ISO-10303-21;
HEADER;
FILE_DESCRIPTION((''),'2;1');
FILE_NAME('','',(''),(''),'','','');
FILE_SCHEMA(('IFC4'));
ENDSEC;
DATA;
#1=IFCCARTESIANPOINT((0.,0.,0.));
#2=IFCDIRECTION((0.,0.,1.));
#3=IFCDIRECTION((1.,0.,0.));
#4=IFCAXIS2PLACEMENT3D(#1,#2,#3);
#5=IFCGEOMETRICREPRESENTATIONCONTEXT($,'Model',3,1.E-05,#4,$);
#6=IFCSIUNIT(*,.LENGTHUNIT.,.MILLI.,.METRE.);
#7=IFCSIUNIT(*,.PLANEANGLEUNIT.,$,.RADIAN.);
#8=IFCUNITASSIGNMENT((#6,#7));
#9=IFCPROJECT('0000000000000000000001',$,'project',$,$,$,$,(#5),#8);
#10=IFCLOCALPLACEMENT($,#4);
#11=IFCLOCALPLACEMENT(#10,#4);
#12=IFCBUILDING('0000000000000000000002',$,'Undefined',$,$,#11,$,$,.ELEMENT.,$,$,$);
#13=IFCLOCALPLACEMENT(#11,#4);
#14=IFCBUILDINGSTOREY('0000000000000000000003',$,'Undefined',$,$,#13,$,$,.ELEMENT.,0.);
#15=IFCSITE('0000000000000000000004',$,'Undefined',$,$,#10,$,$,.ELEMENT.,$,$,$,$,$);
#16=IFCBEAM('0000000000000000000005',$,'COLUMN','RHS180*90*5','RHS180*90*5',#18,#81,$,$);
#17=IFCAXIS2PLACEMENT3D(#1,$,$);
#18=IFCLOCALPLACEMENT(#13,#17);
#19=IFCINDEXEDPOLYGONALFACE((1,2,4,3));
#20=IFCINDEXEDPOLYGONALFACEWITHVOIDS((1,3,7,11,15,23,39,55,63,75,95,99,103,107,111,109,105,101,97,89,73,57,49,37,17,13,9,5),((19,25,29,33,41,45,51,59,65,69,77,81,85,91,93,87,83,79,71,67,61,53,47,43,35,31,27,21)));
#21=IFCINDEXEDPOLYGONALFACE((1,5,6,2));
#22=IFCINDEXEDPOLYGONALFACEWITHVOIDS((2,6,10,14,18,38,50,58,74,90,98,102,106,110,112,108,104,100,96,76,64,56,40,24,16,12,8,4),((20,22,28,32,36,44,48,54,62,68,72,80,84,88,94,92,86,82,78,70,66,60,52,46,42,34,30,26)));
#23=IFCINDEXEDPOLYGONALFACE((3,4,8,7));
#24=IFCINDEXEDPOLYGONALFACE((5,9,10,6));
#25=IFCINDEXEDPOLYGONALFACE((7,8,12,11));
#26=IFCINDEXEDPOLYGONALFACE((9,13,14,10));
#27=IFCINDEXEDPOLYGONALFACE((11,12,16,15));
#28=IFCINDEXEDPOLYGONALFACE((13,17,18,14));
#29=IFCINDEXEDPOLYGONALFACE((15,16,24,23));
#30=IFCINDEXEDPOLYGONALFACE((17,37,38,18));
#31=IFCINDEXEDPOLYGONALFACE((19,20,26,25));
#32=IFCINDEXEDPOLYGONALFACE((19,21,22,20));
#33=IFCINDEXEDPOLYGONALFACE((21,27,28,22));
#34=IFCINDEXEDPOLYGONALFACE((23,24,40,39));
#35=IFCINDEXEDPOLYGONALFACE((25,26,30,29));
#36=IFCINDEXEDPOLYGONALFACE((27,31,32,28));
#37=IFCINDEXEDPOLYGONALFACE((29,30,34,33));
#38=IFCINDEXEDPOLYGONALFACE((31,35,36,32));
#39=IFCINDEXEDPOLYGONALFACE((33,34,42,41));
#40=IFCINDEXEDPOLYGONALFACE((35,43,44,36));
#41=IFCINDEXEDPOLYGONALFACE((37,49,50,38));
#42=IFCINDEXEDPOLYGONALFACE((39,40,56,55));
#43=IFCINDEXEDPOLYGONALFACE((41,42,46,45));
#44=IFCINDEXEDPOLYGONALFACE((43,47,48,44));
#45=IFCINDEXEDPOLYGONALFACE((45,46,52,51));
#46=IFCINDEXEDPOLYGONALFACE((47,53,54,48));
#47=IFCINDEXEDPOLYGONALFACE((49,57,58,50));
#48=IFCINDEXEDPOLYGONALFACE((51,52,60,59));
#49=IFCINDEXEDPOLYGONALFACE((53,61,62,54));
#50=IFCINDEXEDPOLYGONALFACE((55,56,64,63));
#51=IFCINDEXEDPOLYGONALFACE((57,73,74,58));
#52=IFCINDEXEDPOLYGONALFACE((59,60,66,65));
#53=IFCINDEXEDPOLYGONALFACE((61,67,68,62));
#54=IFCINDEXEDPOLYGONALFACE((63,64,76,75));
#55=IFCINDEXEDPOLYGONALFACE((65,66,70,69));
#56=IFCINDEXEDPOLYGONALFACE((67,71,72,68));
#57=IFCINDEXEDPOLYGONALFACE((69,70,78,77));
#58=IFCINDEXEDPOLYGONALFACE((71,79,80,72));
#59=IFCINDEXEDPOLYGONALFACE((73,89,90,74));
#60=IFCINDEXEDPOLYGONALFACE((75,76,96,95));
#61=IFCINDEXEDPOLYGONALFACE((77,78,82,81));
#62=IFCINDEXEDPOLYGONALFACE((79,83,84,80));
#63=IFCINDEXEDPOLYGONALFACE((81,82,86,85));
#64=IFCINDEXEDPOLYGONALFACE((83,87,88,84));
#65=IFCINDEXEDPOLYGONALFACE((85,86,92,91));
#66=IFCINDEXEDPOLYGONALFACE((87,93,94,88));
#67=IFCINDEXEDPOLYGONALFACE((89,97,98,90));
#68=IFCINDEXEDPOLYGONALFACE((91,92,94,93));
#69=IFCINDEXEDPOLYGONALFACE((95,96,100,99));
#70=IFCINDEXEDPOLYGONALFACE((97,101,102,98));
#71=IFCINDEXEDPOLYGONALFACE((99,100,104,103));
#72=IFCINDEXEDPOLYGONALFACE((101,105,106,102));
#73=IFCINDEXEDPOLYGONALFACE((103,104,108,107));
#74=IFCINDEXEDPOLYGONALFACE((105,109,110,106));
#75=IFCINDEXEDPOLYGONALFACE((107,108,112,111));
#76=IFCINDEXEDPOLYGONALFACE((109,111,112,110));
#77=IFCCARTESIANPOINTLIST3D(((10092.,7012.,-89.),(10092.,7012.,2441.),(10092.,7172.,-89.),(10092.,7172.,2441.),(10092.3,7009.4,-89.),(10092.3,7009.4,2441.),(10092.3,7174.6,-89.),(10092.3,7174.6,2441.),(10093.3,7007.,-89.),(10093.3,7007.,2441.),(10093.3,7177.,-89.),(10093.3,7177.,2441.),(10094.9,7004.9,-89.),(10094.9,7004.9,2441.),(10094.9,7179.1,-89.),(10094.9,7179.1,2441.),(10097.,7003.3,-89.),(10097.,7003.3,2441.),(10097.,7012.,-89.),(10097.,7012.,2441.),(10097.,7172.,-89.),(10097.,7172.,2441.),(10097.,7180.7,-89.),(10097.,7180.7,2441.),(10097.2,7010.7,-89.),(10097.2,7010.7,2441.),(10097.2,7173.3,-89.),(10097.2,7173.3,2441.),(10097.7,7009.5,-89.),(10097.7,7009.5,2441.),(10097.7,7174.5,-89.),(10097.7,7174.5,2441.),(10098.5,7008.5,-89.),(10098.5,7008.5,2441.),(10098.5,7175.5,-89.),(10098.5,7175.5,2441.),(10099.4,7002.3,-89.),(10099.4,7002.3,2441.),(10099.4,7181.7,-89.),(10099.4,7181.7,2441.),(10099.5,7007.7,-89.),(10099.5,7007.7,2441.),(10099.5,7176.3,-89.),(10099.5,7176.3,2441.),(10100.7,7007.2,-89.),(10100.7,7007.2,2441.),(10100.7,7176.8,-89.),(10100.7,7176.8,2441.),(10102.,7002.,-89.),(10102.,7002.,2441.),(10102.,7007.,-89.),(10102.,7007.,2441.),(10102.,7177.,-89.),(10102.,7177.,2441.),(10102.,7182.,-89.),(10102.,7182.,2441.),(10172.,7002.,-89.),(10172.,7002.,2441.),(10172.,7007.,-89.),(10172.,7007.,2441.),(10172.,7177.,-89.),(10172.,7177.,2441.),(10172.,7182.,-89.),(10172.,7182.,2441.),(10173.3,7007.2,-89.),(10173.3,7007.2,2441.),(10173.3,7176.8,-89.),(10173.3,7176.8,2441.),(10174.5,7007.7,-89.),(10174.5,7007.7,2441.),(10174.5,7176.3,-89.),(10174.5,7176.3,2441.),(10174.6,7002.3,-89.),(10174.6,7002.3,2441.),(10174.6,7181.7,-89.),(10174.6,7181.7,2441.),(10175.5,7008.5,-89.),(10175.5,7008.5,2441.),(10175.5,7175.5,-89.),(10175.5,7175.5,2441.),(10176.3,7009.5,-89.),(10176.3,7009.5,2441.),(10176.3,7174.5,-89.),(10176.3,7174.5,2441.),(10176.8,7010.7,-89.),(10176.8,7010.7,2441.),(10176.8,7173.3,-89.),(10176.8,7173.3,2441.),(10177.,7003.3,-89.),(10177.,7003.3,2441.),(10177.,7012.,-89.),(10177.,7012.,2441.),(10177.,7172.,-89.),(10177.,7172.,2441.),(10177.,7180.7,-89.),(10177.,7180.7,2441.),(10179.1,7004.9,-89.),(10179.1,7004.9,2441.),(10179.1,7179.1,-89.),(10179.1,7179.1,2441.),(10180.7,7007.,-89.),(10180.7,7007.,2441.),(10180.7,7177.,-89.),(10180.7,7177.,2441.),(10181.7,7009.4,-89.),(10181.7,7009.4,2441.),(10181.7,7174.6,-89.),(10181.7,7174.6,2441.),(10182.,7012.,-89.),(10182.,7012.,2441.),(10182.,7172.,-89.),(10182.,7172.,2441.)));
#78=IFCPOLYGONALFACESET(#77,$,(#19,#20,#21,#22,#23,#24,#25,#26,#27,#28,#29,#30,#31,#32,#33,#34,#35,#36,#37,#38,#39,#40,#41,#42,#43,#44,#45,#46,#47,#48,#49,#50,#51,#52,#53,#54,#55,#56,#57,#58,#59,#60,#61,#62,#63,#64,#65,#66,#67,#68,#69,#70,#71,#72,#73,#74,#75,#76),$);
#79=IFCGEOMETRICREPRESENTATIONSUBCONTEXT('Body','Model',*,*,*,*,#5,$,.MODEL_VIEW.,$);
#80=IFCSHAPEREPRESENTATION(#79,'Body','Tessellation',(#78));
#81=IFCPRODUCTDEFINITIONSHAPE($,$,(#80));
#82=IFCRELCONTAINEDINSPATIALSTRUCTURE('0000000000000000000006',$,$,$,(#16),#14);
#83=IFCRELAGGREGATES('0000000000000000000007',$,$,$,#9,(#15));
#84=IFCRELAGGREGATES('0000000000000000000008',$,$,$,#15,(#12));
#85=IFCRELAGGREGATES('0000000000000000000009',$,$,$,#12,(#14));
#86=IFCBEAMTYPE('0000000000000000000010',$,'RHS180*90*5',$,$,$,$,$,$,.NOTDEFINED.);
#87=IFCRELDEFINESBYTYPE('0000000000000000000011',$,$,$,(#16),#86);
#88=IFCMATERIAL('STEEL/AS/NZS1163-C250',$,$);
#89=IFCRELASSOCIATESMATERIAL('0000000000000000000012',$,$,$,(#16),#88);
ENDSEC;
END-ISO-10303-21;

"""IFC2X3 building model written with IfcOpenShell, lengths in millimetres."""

from ifc_helpers import new_model, si_unit, frame, origin_with_axes, origin_2d_with_axis, place, context, subcontext, project, spatial, hollow_rectangle, extrude, material, type_object, element, save


model = new_model("IFC2X3")

# Units and contexts
model_context = context("Model", 3, precision=1e-05, world=origin_with_axes())
body_context = subcontext(model_context, "Body", "Model", "MODEL_VIEW")
ifc_project = project(units=[si_unit("LENGTHUNIT", "METRE", prefix="MILLI"), si_unit("PLANEANGLEUNIT", "RADIAN")], contexts=[model_context])

# Site, building, storey
site_placement = place(None, origin_with_axes())
site = spatial("IfcSite", under=ifc_project, at=site_placement, Name="Undefined", CompositionType="ELEMENT")
building_placement = place(site_placement, origin_with_axes())
building = spatial("IfcBuilding", under=site, at=building_placement, Name="Undefined", CompositionType="ELEMENT")
storey_placement = place(building_placement, origin_with_axes())
storey = spatial("IfcBuildingStorey", under=building, at=storey_placement, Name="Undefined", CompositionType="ELEMENT", Elevation=0.0)

# Shared definitions
ifc_material_1 = material(Name="STEEL/AS/NZS1163-C250")

# Beam
beam_type_1 = type_object("IfcBeamType", Name="RHS180*90*5", PredefinedType="NOTDEFINED")
beam_1_placement = place(storey_placement, frame((10137.0, 7092.0, 2441.0), z_axis=(0.0, 1.0, 0.0), x_axis=(0.0, 0.0, -1.0)))
element("IfcBeam", 1, at=beam_1_placement, inside=storey, type_object=beam_type_1, material=ifc_material_1, Name="COLUMN", Description="RHS180*90*5", ObjectType="RHS180*90*5", context=body_context, shape_type="SweptSolid", body=[
    extrude(hollow_rectangle(XDim=90.0, YDim=180.0, WallThickness=5.0, InnerFilletRadius=5.0, OuterFilletRadius=10.0, at=origin_2d_with_axis()), frame((2530.0, 0.0, 0.0), z_axis=(-1.0, 0.0, 0.0), x_axis=(0.0, -1.0, 0.0)), (0.0, 0.0, 1.0), 2530.0),
])

save(model, "model.ifc")
